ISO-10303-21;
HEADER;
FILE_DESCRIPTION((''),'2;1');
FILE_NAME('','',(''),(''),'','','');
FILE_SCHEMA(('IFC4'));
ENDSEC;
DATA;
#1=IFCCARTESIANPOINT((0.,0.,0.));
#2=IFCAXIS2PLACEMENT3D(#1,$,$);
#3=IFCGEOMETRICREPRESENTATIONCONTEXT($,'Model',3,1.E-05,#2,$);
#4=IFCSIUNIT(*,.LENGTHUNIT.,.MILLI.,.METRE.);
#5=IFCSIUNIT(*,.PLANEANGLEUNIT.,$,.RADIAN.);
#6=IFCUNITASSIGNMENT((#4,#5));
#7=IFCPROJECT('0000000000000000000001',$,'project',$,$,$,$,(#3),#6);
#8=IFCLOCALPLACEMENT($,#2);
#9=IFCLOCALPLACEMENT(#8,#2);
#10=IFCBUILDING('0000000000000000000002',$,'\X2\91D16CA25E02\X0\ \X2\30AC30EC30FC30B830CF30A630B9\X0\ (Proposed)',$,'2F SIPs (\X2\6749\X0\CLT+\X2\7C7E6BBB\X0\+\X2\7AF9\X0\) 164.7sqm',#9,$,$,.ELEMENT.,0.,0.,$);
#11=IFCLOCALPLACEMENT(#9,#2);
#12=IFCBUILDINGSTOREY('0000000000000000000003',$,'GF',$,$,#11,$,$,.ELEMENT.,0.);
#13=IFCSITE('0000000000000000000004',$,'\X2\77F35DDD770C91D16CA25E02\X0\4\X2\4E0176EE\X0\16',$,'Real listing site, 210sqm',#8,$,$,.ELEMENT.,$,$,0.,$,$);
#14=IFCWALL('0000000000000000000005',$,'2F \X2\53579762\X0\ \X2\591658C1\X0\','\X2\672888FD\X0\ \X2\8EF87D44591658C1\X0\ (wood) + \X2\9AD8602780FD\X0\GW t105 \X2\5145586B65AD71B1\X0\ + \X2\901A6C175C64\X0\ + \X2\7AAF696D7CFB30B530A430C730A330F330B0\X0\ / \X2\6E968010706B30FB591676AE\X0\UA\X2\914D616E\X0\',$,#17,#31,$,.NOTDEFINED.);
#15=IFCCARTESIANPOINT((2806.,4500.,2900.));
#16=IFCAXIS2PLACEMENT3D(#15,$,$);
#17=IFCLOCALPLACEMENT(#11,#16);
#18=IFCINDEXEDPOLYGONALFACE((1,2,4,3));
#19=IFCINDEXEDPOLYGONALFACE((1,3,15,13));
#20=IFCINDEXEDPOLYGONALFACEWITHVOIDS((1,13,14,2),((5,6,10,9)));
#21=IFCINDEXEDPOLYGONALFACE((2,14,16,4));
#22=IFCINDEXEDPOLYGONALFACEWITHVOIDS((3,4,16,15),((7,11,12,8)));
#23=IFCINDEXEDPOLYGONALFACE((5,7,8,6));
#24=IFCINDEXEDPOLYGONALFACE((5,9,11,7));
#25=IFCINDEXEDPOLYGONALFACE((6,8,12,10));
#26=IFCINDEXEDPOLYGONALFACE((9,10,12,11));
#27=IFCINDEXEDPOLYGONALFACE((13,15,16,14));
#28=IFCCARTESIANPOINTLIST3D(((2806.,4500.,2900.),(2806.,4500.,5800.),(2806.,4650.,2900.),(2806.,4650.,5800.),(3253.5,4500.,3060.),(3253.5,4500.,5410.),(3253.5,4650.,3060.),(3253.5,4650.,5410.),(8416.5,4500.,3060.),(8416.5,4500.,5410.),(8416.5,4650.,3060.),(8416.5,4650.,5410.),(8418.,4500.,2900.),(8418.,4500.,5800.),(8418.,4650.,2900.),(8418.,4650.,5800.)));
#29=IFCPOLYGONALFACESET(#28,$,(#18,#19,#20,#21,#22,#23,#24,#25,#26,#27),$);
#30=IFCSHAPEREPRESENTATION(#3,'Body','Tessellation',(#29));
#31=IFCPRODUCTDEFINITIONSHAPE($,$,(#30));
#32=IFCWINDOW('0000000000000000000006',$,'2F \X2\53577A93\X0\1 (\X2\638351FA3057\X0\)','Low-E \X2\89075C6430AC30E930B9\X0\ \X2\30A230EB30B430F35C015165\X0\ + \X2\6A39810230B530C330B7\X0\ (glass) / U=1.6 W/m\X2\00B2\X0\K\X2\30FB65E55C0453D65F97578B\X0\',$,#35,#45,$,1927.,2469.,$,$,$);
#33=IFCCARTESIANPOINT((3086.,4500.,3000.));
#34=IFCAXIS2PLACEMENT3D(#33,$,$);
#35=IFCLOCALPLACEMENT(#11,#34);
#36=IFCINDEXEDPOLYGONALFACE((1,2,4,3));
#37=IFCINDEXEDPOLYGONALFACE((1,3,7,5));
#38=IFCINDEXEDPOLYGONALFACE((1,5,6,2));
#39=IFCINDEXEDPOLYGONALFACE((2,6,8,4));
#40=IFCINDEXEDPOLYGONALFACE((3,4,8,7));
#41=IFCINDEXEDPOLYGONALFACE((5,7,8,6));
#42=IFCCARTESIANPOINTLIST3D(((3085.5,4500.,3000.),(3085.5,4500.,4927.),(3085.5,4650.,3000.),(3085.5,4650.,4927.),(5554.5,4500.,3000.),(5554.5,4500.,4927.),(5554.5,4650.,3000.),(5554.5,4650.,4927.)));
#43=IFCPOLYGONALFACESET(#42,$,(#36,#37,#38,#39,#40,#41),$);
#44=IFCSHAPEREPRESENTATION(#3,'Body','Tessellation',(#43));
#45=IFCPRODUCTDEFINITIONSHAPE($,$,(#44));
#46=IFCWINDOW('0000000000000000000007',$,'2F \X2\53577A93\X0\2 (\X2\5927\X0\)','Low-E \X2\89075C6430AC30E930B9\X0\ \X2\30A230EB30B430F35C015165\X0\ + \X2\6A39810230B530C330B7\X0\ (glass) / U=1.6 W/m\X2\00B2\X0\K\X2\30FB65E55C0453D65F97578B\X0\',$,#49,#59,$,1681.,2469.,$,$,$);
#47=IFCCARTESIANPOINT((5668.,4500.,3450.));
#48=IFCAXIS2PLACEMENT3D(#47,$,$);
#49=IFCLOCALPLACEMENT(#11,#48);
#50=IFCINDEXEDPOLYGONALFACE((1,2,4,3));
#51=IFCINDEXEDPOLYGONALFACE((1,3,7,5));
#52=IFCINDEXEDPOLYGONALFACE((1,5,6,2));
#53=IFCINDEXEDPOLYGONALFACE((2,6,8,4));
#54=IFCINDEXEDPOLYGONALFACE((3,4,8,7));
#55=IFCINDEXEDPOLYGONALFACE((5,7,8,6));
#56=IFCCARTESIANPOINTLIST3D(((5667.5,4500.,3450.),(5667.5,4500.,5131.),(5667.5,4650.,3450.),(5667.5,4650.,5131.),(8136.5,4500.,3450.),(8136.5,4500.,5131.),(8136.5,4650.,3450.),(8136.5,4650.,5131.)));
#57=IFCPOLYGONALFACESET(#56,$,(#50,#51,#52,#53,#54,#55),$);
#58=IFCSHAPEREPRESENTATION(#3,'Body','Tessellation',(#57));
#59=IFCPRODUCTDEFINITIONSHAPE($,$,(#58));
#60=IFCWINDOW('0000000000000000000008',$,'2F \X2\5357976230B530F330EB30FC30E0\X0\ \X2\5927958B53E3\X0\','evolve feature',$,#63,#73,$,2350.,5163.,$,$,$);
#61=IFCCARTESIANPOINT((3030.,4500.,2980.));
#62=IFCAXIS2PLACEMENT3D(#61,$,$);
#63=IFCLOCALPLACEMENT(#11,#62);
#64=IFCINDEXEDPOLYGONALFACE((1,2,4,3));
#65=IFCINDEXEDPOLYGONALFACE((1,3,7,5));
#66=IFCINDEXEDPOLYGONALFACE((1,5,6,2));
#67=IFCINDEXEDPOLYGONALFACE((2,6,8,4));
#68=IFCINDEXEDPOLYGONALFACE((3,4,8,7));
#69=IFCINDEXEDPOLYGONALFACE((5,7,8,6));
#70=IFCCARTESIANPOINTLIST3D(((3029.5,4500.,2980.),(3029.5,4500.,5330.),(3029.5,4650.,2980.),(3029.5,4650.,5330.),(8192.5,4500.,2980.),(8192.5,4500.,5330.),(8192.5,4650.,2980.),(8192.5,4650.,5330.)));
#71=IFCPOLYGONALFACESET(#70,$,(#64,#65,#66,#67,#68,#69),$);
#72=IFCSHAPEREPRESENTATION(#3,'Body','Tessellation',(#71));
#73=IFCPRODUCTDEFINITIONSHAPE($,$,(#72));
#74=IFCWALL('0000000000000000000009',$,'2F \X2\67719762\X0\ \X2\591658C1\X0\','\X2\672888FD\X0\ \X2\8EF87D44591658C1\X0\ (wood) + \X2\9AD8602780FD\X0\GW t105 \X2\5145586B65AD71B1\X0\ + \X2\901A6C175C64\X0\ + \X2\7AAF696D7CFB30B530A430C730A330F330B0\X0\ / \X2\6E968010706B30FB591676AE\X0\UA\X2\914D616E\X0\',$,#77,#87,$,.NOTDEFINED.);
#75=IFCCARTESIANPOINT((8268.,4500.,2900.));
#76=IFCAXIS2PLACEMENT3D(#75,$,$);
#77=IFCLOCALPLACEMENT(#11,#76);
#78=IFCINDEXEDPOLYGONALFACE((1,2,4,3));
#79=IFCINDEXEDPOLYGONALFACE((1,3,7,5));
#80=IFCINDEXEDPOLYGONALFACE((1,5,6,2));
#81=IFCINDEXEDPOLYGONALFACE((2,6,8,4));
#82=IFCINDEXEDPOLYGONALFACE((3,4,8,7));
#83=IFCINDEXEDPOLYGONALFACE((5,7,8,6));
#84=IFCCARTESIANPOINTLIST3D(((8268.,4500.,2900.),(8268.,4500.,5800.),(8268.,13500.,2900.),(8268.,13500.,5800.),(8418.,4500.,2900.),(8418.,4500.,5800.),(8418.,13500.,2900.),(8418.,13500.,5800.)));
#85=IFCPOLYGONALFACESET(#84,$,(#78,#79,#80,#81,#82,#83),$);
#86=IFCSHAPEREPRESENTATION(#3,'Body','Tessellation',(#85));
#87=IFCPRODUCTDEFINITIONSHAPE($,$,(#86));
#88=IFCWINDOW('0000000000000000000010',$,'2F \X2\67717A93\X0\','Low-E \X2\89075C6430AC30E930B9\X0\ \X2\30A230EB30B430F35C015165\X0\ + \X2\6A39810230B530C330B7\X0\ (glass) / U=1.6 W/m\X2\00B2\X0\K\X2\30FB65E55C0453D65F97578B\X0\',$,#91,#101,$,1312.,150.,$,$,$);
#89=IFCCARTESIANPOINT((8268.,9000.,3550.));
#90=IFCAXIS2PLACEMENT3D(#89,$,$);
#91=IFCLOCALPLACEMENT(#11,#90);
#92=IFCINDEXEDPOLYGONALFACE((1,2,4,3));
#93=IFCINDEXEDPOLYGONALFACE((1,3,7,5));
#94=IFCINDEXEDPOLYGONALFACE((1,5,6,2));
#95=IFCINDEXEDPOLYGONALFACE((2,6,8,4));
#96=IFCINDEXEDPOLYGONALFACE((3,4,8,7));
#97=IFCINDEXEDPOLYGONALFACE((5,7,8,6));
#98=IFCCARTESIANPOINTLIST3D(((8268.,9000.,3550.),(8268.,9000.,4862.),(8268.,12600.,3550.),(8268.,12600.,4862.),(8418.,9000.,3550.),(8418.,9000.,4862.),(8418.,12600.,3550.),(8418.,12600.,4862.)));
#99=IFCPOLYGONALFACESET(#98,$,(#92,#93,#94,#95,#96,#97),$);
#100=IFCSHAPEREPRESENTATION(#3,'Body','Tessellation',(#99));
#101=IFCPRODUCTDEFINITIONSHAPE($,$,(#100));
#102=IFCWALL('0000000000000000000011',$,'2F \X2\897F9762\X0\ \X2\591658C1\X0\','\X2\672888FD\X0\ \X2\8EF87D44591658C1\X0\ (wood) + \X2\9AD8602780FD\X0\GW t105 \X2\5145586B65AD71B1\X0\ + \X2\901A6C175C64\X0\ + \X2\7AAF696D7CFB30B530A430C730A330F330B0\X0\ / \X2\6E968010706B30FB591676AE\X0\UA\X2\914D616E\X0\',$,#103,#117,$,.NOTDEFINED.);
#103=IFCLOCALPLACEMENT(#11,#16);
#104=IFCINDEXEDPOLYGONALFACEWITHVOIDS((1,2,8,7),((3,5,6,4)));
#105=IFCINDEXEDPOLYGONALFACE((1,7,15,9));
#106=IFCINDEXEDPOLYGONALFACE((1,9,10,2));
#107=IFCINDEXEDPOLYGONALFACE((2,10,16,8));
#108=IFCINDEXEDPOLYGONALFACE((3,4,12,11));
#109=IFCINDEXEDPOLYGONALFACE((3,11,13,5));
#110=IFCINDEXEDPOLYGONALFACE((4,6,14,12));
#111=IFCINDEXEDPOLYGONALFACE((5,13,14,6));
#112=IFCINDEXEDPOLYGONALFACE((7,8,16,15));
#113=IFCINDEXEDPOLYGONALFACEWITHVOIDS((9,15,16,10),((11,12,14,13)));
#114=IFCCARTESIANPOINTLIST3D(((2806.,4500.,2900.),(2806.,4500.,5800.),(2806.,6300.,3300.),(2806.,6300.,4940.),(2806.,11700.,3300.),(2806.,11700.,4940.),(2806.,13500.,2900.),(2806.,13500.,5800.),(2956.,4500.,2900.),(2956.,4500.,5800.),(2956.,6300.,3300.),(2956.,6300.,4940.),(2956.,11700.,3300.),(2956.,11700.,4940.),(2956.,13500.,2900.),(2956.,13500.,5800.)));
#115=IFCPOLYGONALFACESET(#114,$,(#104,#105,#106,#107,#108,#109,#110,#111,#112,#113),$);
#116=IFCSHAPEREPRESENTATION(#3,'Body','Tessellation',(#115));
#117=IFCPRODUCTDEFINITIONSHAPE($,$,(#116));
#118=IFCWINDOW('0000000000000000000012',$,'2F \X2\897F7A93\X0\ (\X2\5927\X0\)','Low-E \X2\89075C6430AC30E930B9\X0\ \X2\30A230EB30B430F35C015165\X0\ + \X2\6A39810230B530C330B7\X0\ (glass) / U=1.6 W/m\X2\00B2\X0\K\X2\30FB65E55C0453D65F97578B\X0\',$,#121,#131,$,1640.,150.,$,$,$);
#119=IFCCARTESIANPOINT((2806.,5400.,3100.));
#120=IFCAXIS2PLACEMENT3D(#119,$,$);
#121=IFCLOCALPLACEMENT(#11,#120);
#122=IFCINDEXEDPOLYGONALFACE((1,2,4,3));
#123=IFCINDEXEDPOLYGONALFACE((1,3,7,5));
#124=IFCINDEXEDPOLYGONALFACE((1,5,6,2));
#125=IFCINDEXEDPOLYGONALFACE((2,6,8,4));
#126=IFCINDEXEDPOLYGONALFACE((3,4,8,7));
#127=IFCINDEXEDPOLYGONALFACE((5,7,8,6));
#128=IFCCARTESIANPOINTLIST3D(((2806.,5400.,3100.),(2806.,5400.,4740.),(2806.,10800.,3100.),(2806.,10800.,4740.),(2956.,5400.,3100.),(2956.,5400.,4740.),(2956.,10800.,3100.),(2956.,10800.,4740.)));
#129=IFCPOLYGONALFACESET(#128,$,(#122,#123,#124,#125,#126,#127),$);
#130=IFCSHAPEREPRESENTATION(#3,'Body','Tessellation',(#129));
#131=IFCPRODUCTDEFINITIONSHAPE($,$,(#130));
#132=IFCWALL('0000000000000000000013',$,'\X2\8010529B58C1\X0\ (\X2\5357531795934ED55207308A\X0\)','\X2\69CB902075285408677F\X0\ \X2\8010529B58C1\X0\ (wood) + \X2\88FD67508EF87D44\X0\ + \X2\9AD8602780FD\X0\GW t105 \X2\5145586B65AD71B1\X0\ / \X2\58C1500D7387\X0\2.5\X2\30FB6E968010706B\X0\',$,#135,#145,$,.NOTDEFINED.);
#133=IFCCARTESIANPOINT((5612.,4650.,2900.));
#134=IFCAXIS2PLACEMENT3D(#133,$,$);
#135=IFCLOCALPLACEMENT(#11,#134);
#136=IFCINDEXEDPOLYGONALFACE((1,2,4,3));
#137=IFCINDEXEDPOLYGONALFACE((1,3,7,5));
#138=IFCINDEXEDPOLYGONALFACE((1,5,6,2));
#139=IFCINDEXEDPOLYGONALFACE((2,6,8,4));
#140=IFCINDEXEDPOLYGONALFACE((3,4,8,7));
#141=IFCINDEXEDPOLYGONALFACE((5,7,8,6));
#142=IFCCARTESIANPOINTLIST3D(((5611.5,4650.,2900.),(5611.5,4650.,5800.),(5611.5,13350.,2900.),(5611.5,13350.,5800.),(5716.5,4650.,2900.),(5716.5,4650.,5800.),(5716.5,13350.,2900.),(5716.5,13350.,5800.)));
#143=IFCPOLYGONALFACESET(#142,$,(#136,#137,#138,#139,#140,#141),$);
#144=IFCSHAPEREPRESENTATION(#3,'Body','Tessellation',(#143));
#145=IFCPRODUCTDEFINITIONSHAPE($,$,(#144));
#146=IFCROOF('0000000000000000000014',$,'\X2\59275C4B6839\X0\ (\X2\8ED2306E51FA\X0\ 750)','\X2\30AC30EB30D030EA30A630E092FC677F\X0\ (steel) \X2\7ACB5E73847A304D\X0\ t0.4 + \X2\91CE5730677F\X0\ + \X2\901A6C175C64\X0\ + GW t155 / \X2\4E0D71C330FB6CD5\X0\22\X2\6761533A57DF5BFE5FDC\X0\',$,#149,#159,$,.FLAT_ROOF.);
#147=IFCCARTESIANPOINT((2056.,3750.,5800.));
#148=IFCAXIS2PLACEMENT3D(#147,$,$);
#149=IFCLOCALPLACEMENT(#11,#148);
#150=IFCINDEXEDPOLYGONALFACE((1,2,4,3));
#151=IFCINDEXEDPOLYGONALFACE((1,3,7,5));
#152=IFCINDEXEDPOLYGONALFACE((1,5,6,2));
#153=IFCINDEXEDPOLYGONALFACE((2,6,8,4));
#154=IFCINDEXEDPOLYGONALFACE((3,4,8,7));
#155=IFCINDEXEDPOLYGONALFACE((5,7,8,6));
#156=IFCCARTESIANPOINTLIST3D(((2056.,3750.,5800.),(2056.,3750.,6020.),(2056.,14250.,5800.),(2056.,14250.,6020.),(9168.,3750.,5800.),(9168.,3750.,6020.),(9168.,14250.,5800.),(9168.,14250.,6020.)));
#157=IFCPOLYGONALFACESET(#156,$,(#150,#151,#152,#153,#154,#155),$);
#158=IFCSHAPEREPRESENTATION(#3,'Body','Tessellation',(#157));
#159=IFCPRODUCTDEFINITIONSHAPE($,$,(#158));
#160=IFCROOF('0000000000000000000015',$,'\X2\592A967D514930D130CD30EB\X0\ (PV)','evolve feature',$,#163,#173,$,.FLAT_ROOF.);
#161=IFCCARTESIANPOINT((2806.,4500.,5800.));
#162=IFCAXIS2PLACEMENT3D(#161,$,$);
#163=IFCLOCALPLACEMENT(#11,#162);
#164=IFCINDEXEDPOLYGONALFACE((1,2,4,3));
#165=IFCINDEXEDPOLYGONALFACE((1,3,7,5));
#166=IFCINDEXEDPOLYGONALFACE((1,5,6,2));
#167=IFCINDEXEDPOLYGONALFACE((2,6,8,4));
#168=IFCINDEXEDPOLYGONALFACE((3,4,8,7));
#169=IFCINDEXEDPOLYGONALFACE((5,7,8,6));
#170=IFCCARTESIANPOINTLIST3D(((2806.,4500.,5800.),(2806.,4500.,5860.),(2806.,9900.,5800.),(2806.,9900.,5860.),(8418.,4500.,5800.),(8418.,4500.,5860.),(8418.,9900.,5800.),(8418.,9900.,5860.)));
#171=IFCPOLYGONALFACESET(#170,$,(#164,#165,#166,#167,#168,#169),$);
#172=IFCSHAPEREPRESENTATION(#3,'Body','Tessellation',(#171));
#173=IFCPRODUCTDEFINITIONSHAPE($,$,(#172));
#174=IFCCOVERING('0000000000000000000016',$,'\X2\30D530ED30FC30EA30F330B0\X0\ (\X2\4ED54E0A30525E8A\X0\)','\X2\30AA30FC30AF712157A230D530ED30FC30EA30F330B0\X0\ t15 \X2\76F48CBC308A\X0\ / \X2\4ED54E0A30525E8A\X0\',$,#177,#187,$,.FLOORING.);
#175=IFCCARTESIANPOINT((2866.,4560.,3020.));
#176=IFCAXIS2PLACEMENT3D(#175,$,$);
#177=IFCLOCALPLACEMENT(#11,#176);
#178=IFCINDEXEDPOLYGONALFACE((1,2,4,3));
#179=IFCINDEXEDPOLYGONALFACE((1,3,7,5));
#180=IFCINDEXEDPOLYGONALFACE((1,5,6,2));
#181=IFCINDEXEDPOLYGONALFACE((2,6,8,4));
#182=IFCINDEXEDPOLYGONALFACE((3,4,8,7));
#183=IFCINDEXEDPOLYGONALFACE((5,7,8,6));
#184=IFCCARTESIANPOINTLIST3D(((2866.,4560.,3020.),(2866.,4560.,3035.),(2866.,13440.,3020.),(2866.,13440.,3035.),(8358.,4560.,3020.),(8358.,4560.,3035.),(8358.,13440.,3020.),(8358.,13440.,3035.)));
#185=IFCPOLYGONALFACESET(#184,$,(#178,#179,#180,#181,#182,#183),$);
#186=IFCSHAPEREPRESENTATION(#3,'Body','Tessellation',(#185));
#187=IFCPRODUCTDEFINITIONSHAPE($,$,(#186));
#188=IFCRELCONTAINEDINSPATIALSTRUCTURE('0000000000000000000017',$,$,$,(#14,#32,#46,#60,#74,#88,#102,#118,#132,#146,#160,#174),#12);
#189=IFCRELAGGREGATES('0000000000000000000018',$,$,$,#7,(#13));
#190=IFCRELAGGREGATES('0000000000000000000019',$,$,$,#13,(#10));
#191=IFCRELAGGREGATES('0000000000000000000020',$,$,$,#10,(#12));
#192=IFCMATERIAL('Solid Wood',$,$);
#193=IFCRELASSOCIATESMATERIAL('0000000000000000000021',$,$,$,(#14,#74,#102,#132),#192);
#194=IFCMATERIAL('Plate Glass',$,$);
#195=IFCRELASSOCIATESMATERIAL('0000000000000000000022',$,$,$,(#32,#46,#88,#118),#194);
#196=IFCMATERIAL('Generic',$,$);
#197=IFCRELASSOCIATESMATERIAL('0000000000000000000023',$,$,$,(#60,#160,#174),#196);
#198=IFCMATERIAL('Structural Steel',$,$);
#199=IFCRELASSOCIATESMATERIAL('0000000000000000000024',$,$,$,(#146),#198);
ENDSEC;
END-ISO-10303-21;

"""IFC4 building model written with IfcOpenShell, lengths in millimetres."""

from ifc_helpers import new_model, si_unit, frame, frame_2d, origin, place, context, project, spatial, rectangle, extrude, material, element, fill, save


model = new_model("IFC4")

# Units and contexts
model_context = context("Model", 3, precision=1e-05, world=origin())
ifc_project = project(units=[si_unit("LENGTHUNIT", "METRE", prefix="MILLI"), si_unit("PLANEANGLEUNIT", "RADIAN")], contexts=[model_context])

# Site, building, storey
site_placement = place(None, origin())
site = spatial("IfcSite", under=ifc_project, at=site_placement, Name="石川県金沢市4丁目16", ObjectType="Real listing site, 210sqm", CompositionType="ELEMENT", RefElevation=0.0)
building_placement = place(site_placement, origin())
building = spatial("IfcBuilding", under=site, at=building_placement, Name="金沢市 ガレージハウス (Proposed)", ObjectType="2F SIPs (杉CLT+籾殻+竹) 164.7sqm", CompositionType="ELEMENT", ElevationOfRefHeight=0.0, ElevationOfTerrain=0.0)
storey_placement = place(building_placement, origin())
storey = spatial("IfcBuildingStorey", under=building, at=storey_placement, Name="GF", CompositionType="ELEMENT", Elevation=0.0)

# Shared definitions
ifc_material_1 = material(Name="Solid Wood")

# Wall, openings, windows
wall_1_placement = place(storey_placement, frame((2806.0, 4500.0, 2900.0)))
wall_1 = element("IfcWall", 1, at=wall_1_placement, inside=storey, material=ifc_material_1, Name="2F 南面 外壁", Description="木製 軸組外壁 (wood) + 高性能GW t105 充填断熱 + 通気層 + 窯業系サイディング / 準耐火・外皮UA配慮", PredefinedType="NOTDEFINED", context=model_context, shape_type="SweptSolid", body=[
    extrude(rectangle(XDim=5612.0, YDim=150.0, at=frame_2d((2806.0, 75.0))), frame((2806.0, 4500.0, 2900.0)), (0.0, 0.0, 1.0), 2900.0),
])
opening_1_placement = place(storey_placement, frame((3086.0, 4500.0, 3000.0)))
opening_1 = element("IfcOpeningElement", 2, at=opening_1_placement, cuts=wall_1, PredefinedType="NOTDEFINED", context=model_context, shape_type="SweptSolid", body=[
    extrude(rectangle(XDim=2469.0, YDim=150.0, at=frame_2d((1234.0, 75.0))), frame((3086.0, 4500.0, 3000.0)), (0.0, 0.0, 1.0), 1927.0),
])
opening_2_placement = place(storey_placement, frame((5668.0, 4500.0, 3450.0)))
opening_2 = element("IfcOpeningElement", 3, at=opening_2_placement, cuts=wall_1, PredefinedType="NOTDEFINED", context=model_context, shape_type="SweptSolid", body=[
    extrude(rectangle(XDim=2469.0, YDim=150.0, at=frame_2d((1234.0, 75.0))), frame((5668.0, 4500.0, 3450.0)), (0.0, 0.0, 1.0), 1681.0),
])
opening_3_placement = place(storey_placement, frame((3030.0, 4500.0, 2980.0)))
opening_3 = element("IfcOpeningElement", 4, at=opening_3_placement, cuts=wall_1, PredefinedType="NOTDEFINED", context=model_context, shape_type="SweptSolid", body=[
    extrude(rectangle(XDim=5163.0, YDim=150.0, at=frame_2d((2581.0, 75.0))), frame((3030.0, 4500.0, 2980.0)), (0.0, 0.0, 1.0), 2350.0),
])
ifc_material_2 = material(Name="Plate Glass")
window_1_placement = place(storey_placement, frame((3086.0, 4500.0, 3000.0)))
window_1 = element("IfcWindow", 5, at=window_1_placement, inside=storey, material=ifc_material_2, Name="2F 南窓1 (掃出し)", Description="Low-E 複層ガラス アルゴン封入 + 樹脂サッシ (glass) / U=1.6 W/m²K・日射取得型", OverallHeight=1927.0, OverallWidth=2469.0, context=model_context, shape_type="SweptSolid", body=[
    extrude(rectangle(XDim=2469.0, YDim=150.0, at=frame_2d((1234.0, 75.0))), frame((3086.0, 4500.0, 3000.0)), (0.0, 0.0, 1.0), 1927.0),
])
fill(opening_1, window_1)
window_2_placement = place(storey_placement, frame((5668.0, 4500.0, 3450.0)))
window_2 = element("IfcWindow", 6, at=window_2_placement, inside=storey, material=ifc_material_2, Name="2F 南窓2 (大)", Description="Low-E 複層ガラス アルゴン封入 + 樹脂サッシ (glass) / U=1.6 W/m²K・日射取得型", OverallHeight=1681.0, OverallWidth=2469.0, context=model_context, shape_type="SweptSolid", body=[
    extrude(rectangle(XDim=2469.0, YDim=150.0, at=frame_2d((1234.0, 75.0))), frame((5668.0, 4500.0, 3450.0)), (0.0, 0.0, 1.0), 1681.0),
])
fill(opening_2, window_2)
ifc_material_3 = material(Name="Generic")
window_3_placement = place(storey_placement, frame((3030.0, 4500.0, 2980.0)))
window_3 = element("IfcWindow", 7, at=window_3_placement, inside=storey, material=ifc_material_3, Name="2F 南面サンルーム 大開口", Description="evolve feature", OverallHeight=2350.0, OverallWidth=5163.0, context=model_context, shape_type="SweptSolid", body=[
    extrude(rectangle(XDim=5163.0, YDim=150.0, at=frame_2d((2581.0, 75.0))), frame((3030.0, 4500.0, 2980.0)), (0.0, 0.0, 1.0), 2350.0),
])
fill(opening_3, window_3)

# Walls, openings, windows
wall_2_placement = place(storey_placement, frame((8268.0, 4500.0, 2900.0)))
wall_2 = element("IfcWall", 8, at=wall_2_placement, inside=storey, material=ifc_material_1, Name="2F 東面 外壁", Description="木製 軸組外壁 (wood) + 高性能GW t105 充填断熱 + 通気層 + 窯業系サイディング / 準耐火・外皮UA配慮", PredefinedType="NOTDEFINED", context=model_context, shape_type="SweptSolid", body=[
    extrude(rectangle(XDim=150.0, YDim=9000.0, at=frame_2d((75.0, 4500.0))), frame((8268.0, 4500.0, 2900.0)), (0.0, 0.0, 1.0), 2900.0),
])
opening_4_placement = place(storey_placement, frame((8268.0, 9000.0, 3550.0)))
opening_4 = element("IfcOpeningElement", 9, at=opening_4_placement, cuts=wall_2, PredefinedType="NOTDEFINED", context=model_context, shape_type="SweptSolid", body=[
    extrude(rectangle(XDim=150.0, YDim=3600.0, at=frame_2d((75.0, 1800.0))), frame((8268.0, 9000.0, 3550.0)), (0.0, 0.0, 1.0), 1312.0),
])
window_4_placement = place(storey_placement, frame((8268.0, 9000.0, 3550.0)))
window_4 = element("IfcWindow", 10, at=window_4_placement, inside=storey, material=ifc_material_2, Name="2F 東窓", Description="Low-E 複層ガラス アルゴン封入 + 樹脂サッシ (glass) / U=1.6 W/m²K・日射取得型", OverallHeight=1312.0, OverallWidth=150.0, context=model_context, shape_type="SweptSolid", body=[
    extrude(rectangle(XDim=150.0, YDim=3600.0, at=frame_2d((75.0, 1800.0))), frame((8268.0, 9000.0, 3550.0)), (0.0, 0.0, 1.0), 1312.0),
])
fill(opening_4, window_4)
wall_3_placement = place(storey_placement, frame((2806.0, 4500.0, 2900.0)))
wall_3 = element("IfcWall", 11, at=wall_3_placement, inside=storey, material=ifc_material_1, Name="2F 西面 外壁", Description="木製 軸組外壁 (wood) + 高性能GW t105 充填断熱 + 通気層 + 窯業系サイディング / 準耐火・外皮UA配慮", PredefinedType="NOTDEFINED", context=model_context, shape_type="SweptSolid", body=[
    extrude(rectangle(XDim=150.0, YDim=9000.0, at=frame_2d((75.0, 4500.0))), frame((2806.0, 4500.0, 2900.0)), (0.0, 0.0, 1.0), 2900.0),
])
opening_5_placement = place(storey_placement, frame((2806.0, 5400.0, 3100.0)))
opening_5 = element("IfcOpeningElement", 12, at=opening_5_placement, cuts=wall_3, PredefinedType="NOTDEFINED", context=model_context, shape_type="SweptSolid", body=[
    extrude(rectangle(XDim=150.0, YDim=5400.0, at=frame_2d((75.0, 2700.0))), frame((2806.0, 5400.0, 3100.0)), (0.0, 0.0, 1.0), 1640.0),
])
window_5_placement = place(storey_placement, frame((2806.0, 5400.0, 3100.0)))
window_5 = element("IfcWindow", 13, at=window_5_placement, inside=storey, material=ifc_material_2, Name="2F 西窓 (大)", Description="Low-E 複層ガラス アルゴン封入 + 樹脂サッシ (glass) / U=1.6 W/m²K・日射取得型", OverallHeight=1640.0, OverallWidth=150.0, context=model_context, shape_type="SweptSolid", body=[
    extrude(rectangle(XDim=150.0, YDim=5400.0, at=frame_2d((75.0, 2700.0))), frame((2806.0, 5400.0, 3100.0)), (0.0, 0.0, 1.0), 1640.0),
])
fill(opening_5, window_5)

# Wall
wall_4_placement = place(storey_placement, frame((5612.0, 4650.0, 2900.0)))
element("IfcWall", 14, at=wall_4_placement, inside=storey, material=ifc_material_1, Name="耐力壁 (南北間仕切り)", Description="構造用合板 耐力壁 (wood) + 製材軸組 + 高性能GW t105 充填断熱 / 壁倍率2.5・準耐火", PredefinedType="NOTDEFINED", context=model_context, shape_type="SweptSolid", body=[
    extrude(rectangle(XDim=105.0, YDim=8700.0, at=frame_2d((52.0, 4350.0))), frame((5612.0, 4650.0, 2900.0)), (0.0, 0.0, 1.0), 2900.0),
])

# Roofs
ifc_material_4 = material(Name="Structural Steel")
roof_1_placement = place(storey_placement, frame((2056.0, 3750.0, 5800.0)))
element("IfcRoof", 15, at=roof_1_placement, inside=storey, material=ifc_material_4, Name="大屋根 (軒の出 750)", Description="ガルバリウム鋼板 (steel) 立平葺き t0.4 + 野地板 + 通気層 + GW t155 / 不燃・法22条区域対応", PredefinedType="FLAT_ROOF", context=model_context, shape_type="SweptSolid", body=[
    extrude(rectangle(XDim=7112.0, YDim=10500.0, at=frame_2d((3556.0, 5250.0))), frame((2056.0, 3750.0, 5800.0)), (0.0, 0.0, 1.0), 220.0),
])
roof_2_placement = place(storey_placement, frame((2806.0, 4500.0, 5800.0)))
element("IfcRoof", 16, at=roof_2_placement, inside=storey, material=ifc_material_3, Name="太陽光パネル (PV)", Description="evolve feature", PredefinedType="FLAT_ROOF", context=model_context, shape_type="SweptSolid", body=[
    extrude(rectangle(XDim=5612.0, YDim=5400.0, at=frame_2d((2806.0, 2700.0))), frame((2806.0, 4500.0, 5800.0)), (0.0, 0.0, 1.0), 60.0),
])

# Covering
covering_placement = place(storey_placement, frame((2866.0, 4560.0, 3020.0)))
element("IfcCovering", 17, at=covering_placement, inside=storey, material=ifc_material_3, Name="フローリング (仕上げ床)", Description="オーク無垢フローリング t15 直貼り / 仕上げ床", PredefinedType="FLOORING", context=model_context, shape_type="SweptSolid", body=[
    extrude(rectangle(XDim=5492.0, YDim=8880.0, at=frame_2d((2746.0, 4440.0))), frame((2866.0, 4560.0, 3020.0)), (0.0, 0.0, 1.0), 15.0),
])

save(model, "model.ifc")
